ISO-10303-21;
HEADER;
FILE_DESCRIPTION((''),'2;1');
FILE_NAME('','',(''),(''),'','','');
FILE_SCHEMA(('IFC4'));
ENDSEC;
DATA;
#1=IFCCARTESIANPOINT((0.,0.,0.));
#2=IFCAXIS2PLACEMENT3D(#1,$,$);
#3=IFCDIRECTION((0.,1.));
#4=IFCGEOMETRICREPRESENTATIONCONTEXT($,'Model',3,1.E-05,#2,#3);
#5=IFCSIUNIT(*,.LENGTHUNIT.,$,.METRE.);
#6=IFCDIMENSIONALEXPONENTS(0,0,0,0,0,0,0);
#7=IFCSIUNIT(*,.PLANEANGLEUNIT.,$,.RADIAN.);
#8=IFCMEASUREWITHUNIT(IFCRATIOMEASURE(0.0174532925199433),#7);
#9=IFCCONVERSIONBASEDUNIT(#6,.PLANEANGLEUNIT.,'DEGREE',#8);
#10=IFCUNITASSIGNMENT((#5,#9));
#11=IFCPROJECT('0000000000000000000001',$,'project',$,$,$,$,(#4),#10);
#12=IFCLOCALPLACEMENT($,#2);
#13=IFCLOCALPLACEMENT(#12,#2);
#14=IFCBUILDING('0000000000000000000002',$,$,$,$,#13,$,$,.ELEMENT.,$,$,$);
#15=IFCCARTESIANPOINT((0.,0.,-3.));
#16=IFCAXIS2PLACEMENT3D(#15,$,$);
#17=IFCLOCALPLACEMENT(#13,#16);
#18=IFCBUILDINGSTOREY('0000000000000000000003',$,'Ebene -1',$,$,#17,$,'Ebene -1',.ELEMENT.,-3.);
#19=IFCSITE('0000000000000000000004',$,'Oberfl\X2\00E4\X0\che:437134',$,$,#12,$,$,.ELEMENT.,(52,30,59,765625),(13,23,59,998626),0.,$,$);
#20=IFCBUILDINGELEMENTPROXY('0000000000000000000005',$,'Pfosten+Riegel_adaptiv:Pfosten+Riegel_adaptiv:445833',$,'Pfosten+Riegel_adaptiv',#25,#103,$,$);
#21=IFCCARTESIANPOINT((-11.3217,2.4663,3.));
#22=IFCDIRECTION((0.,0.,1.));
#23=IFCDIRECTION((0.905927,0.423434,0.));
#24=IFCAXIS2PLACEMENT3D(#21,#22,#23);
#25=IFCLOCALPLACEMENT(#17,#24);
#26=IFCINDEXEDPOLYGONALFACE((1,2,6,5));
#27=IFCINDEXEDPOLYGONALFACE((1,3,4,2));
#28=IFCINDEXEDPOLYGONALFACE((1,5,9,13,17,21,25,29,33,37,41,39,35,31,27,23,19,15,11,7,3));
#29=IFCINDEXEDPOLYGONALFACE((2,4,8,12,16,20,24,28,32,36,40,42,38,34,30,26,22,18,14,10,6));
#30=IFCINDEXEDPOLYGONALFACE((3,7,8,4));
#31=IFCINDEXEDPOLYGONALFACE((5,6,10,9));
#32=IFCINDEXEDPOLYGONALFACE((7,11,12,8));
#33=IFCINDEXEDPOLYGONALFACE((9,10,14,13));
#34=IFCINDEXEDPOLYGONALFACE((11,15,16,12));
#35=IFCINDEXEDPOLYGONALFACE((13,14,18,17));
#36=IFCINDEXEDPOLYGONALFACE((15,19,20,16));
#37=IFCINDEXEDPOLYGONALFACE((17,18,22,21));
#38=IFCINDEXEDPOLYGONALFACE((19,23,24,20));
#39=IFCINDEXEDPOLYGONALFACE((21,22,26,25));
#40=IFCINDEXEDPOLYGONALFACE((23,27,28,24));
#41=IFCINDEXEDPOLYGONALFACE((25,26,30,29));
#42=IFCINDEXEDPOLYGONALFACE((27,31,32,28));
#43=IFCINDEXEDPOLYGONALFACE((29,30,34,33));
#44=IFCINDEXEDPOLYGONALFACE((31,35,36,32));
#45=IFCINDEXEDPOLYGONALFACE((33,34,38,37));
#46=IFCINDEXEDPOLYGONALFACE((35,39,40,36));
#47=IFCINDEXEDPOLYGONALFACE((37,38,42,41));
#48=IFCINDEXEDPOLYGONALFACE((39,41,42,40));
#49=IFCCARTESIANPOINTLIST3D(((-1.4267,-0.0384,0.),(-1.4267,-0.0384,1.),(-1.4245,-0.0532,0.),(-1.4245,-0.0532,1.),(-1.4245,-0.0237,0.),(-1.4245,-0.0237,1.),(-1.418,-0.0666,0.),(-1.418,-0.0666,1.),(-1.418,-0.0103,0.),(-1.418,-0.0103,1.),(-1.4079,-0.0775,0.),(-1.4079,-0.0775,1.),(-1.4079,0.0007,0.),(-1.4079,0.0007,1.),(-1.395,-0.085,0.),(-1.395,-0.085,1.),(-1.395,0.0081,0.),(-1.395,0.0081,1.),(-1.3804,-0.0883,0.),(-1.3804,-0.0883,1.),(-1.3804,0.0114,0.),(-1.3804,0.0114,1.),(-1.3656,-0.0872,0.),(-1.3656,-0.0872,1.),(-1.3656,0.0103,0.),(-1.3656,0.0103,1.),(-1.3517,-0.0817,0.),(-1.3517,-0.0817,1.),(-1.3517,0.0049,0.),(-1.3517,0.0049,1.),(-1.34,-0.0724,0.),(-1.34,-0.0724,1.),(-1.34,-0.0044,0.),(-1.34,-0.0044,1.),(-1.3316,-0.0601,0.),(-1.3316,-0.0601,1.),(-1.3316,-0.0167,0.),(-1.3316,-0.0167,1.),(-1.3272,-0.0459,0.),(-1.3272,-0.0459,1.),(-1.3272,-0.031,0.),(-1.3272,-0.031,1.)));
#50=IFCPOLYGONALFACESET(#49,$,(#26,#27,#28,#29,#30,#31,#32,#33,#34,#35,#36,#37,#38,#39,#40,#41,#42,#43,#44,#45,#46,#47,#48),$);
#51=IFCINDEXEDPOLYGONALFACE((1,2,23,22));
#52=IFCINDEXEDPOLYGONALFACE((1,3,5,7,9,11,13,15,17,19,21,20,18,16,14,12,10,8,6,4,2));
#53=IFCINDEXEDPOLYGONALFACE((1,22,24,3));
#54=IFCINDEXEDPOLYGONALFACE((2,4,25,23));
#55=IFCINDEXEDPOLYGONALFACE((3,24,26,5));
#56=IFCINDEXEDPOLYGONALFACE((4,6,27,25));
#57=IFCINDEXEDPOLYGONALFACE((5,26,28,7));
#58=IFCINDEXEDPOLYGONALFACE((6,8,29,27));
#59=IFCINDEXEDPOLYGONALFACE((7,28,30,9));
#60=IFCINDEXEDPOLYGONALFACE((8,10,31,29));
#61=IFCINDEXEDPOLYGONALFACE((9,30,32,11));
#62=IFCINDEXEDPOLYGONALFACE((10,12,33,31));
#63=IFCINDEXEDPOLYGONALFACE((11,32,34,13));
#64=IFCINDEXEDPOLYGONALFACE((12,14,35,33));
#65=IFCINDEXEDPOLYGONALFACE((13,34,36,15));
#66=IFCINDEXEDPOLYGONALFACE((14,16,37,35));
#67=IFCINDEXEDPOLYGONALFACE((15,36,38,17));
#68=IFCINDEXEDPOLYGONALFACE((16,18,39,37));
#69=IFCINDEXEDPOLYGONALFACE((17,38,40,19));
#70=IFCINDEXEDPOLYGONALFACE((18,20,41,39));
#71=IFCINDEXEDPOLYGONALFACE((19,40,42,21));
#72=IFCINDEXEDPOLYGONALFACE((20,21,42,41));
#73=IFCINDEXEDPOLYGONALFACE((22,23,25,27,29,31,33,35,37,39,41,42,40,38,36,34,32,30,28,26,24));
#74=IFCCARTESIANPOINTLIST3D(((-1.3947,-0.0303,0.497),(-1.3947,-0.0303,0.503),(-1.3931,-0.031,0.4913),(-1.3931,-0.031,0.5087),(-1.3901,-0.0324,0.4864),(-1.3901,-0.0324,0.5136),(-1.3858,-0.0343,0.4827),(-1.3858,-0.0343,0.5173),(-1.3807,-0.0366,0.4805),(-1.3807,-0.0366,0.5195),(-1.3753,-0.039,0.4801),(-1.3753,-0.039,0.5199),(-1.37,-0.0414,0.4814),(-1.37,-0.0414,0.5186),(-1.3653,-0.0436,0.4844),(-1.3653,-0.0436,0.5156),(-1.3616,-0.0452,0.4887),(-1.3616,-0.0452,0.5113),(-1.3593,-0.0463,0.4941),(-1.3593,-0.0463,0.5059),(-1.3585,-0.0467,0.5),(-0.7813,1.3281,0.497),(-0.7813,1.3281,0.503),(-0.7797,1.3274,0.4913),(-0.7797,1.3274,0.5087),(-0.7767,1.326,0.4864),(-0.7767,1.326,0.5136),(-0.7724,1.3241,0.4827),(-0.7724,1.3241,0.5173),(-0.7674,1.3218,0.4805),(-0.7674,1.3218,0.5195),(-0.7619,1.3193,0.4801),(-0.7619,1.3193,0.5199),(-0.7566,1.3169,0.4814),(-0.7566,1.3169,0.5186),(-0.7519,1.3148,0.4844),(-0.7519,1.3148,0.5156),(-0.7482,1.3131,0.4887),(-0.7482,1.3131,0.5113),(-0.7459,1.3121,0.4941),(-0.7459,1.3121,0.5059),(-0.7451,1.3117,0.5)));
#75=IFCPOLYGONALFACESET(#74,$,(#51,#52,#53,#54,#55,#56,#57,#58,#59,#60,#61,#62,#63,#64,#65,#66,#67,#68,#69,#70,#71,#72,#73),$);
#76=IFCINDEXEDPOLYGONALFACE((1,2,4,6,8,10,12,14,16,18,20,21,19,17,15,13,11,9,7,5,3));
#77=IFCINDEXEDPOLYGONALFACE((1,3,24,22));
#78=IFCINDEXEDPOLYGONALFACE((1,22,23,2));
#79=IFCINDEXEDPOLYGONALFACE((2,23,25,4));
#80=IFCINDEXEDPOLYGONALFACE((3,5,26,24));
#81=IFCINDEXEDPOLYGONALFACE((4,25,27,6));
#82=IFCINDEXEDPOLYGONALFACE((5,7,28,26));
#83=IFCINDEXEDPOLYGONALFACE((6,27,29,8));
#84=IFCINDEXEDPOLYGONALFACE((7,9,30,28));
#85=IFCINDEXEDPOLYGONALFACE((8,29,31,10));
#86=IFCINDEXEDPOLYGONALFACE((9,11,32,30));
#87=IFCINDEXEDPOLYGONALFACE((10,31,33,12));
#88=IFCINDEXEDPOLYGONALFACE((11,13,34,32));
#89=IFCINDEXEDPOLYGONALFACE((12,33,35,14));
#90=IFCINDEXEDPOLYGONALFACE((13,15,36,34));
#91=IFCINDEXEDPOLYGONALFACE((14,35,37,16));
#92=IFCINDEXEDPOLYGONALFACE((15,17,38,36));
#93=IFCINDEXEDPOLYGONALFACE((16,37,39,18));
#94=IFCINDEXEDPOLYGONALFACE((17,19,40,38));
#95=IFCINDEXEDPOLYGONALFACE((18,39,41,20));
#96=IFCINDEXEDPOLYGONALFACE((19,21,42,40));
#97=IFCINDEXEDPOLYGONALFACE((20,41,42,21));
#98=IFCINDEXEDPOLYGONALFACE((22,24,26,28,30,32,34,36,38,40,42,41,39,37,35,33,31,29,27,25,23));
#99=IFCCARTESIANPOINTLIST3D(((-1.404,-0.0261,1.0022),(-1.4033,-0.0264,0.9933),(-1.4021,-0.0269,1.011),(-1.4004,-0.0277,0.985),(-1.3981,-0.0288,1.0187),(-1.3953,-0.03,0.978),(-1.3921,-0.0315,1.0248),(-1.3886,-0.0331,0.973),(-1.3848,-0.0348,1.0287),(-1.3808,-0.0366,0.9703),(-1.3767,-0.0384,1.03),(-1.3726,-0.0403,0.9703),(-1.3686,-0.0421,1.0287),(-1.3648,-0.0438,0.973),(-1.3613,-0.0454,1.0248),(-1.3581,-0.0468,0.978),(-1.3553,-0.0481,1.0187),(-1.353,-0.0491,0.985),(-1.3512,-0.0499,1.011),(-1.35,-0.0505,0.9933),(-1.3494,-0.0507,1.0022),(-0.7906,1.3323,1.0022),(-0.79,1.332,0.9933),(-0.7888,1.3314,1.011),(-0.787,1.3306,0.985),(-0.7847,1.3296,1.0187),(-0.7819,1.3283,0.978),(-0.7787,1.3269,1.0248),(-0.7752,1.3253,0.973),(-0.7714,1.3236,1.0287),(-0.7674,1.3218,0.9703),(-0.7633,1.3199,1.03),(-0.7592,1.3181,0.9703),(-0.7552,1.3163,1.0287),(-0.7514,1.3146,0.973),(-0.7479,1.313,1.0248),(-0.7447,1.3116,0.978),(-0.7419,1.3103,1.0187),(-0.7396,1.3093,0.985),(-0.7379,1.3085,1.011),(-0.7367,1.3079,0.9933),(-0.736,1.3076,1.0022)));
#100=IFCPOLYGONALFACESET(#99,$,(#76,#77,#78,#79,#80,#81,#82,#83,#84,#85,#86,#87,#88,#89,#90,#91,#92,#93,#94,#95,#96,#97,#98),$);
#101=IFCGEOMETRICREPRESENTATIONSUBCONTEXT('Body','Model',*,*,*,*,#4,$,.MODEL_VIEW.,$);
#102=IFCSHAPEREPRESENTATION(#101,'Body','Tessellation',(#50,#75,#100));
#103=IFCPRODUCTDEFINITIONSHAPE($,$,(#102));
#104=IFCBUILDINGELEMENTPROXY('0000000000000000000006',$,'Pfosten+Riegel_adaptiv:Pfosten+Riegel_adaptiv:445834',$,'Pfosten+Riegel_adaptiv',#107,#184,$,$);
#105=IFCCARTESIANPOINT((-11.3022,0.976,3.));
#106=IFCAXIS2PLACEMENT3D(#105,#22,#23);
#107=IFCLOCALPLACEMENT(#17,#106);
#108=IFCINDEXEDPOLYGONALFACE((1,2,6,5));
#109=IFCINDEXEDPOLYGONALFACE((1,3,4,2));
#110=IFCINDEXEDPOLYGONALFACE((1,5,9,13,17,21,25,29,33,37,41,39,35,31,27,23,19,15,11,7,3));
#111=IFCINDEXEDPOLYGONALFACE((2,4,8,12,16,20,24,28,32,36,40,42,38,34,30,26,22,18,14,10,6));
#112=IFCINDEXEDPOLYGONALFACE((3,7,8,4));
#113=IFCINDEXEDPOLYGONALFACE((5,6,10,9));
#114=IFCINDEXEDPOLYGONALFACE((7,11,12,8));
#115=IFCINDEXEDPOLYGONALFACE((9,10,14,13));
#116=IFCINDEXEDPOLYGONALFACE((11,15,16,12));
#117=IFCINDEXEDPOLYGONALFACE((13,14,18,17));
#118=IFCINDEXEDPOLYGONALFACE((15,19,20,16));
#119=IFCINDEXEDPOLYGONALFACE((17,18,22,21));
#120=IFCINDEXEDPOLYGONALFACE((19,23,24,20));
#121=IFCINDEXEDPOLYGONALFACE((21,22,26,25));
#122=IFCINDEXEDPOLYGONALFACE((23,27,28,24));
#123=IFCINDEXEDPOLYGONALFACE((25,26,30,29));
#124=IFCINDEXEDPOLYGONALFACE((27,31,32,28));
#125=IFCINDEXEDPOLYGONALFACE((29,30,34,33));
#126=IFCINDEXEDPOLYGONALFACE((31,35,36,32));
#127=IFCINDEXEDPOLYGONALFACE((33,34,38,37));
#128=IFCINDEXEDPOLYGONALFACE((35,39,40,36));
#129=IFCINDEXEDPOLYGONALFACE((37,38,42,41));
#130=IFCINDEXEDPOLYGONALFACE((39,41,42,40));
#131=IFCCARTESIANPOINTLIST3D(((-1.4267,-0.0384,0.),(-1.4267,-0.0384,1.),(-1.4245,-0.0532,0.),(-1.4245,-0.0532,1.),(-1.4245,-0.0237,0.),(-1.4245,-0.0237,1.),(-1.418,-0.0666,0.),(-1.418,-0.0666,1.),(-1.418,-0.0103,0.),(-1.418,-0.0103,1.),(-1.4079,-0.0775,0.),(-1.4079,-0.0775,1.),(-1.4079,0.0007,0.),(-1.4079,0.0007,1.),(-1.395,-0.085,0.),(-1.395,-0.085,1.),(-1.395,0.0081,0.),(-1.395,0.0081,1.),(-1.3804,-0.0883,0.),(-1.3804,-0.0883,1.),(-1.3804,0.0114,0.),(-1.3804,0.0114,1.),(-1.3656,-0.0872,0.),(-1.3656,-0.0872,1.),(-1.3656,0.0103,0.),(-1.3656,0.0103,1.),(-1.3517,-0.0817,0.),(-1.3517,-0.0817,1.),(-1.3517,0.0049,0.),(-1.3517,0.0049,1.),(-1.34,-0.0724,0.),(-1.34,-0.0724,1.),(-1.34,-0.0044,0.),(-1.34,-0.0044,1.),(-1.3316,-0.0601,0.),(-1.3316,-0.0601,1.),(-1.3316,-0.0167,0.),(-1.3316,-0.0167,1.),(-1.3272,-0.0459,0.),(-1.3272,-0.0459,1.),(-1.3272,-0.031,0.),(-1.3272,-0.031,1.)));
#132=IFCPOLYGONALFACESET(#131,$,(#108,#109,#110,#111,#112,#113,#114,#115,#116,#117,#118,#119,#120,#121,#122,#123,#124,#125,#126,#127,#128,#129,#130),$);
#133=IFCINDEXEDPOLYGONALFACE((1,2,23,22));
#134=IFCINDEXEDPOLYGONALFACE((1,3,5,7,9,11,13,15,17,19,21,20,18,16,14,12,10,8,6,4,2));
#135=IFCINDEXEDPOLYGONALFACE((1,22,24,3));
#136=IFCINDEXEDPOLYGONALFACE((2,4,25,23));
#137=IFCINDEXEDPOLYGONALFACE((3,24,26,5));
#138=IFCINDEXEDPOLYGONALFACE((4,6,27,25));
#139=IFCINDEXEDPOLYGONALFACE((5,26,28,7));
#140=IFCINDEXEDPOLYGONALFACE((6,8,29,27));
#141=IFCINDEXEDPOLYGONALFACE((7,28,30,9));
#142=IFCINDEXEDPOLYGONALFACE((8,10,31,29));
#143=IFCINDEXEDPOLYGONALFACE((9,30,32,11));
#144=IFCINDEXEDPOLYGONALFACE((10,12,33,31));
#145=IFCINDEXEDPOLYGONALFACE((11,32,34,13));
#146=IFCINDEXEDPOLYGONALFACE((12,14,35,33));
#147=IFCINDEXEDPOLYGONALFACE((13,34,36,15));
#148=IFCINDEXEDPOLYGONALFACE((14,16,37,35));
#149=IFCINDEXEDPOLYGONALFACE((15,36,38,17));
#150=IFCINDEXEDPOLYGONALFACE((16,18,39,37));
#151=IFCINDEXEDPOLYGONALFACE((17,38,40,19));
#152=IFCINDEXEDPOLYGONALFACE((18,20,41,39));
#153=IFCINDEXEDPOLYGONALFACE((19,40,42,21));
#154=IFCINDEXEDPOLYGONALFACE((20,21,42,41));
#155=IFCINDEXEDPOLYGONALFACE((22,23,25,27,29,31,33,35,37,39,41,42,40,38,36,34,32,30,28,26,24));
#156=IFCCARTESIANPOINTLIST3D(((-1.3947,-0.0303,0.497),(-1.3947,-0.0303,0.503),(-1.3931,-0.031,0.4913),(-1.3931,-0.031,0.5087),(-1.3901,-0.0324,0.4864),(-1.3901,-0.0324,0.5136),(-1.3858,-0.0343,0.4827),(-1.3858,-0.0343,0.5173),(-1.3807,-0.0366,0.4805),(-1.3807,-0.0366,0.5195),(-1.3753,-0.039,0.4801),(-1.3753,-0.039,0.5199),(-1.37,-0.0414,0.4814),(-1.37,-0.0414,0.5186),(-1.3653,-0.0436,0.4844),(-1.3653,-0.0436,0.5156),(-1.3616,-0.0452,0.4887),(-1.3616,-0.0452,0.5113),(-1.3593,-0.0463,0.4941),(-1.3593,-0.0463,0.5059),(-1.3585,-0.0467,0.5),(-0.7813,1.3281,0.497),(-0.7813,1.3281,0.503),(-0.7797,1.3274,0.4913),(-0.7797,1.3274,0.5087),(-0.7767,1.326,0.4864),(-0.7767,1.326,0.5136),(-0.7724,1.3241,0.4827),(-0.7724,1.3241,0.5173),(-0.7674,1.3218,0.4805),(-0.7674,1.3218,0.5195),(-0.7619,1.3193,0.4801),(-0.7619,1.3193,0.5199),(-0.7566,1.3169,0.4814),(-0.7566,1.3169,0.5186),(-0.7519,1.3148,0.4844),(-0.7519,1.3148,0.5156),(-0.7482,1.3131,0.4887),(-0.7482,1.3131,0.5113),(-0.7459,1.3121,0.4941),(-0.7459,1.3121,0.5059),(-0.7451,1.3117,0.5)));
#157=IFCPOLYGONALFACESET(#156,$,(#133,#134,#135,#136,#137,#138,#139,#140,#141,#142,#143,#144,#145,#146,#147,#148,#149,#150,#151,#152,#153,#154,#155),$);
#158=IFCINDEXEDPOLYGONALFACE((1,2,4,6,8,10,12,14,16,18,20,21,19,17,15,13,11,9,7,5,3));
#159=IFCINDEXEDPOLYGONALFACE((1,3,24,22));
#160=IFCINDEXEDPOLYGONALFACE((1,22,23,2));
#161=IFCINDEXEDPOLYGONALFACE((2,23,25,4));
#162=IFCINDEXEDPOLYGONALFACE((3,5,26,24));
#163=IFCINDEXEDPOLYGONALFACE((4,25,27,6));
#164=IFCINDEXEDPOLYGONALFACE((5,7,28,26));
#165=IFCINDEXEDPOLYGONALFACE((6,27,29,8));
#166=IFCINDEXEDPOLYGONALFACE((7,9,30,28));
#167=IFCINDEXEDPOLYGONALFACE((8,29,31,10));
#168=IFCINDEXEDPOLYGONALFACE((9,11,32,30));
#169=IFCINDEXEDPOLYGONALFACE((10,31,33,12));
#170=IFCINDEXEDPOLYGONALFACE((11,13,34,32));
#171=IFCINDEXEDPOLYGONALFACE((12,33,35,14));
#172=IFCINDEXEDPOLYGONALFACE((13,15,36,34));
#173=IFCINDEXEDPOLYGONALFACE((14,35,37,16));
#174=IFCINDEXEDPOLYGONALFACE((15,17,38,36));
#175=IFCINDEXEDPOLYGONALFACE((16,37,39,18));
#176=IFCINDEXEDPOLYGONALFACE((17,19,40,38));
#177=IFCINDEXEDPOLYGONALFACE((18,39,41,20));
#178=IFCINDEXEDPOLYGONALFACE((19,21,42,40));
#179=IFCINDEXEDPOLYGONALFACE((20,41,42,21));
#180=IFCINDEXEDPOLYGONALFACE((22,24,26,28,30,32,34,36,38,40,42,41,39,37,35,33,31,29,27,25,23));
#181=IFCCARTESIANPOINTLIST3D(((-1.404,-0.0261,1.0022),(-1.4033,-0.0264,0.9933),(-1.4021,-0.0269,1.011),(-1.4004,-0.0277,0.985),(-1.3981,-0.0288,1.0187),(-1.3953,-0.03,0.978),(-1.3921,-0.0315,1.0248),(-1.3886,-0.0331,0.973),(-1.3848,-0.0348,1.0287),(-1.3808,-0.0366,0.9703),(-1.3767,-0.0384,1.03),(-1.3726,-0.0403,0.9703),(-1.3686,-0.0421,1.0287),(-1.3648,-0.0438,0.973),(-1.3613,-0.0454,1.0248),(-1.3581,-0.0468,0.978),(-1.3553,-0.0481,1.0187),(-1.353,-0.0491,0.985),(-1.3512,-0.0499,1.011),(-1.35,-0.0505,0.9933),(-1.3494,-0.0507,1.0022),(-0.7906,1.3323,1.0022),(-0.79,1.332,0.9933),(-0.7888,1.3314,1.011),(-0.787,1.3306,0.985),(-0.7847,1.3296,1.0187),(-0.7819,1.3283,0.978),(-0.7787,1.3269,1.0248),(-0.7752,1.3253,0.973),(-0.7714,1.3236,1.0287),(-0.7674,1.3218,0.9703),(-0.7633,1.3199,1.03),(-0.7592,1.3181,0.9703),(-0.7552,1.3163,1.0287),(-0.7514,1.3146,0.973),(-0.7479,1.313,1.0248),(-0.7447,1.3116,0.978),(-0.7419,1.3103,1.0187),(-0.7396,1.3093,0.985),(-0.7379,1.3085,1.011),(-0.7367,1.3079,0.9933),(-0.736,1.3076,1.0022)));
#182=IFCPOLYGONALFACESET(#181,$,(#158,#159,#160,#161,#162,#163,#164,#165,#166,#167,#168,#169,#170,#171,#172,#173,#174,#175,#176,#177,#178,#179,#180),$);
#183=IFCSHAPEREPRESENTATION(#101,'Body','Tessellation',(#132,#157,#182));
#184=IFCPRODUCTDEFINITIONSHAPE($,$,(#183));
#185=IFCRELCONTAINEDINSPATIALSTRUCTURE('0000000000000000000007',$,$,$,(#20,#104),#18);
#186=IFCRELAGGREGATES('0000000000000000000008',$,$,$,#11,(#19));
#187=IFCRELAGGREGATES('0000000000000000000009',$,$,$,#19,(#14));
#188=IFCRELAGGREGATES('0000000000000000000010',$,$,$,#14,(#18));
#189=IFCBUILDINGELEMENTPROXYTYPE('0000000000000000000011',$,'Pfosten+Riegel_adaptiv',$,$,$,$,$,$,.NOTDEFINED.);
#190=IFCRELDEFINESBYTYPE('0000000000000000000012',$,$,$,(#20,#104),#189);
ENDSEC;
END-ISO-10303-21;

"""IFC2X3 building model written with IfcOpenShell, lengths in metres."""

from ifc_helpers import new_model, entity, si_unit, converted_unit, direction, frame, frame_2d, origin, place, context, subcontext, project, spatial, circle, extrude, source, transform, mapped, type_object, type_shapes, element, save


model = new_model("IFC2X3")

# Units and contexts
model_context = context("Model", 3, precision=1e-05, world=origin(), true_north=direction((0.0, 1.0)))
body_context = subcontext(model_context, "Body", "Model", "MODEL_VIEW")
ifc_project = project(units=[si_unit("LENGTHUNIT", "METRE"), converted_unit("PLANEANGLEUNIT", "DEGREE", entity("IfcRatioMeasure", 0.0174532925199433), si_unit("PLANEANGLEUNIT", "RADIAN"), dimensions=[0, 0, 0, 0, 0, 0, 0])], contexts=[model_context])

# Site, building, storey
site_placement = place(None, origin())
site = spatial("IfcSite", under=ifc_project, at=site_placement, Name="Oberfläche:437134", CompositionType="ELEMENT", RefLatitude=(52, 30, 59, 765625), RefLongitude=(13, 23, 59, 998626), RefElevation=0.0)
building_placement = place(site_placement, origin())
building = spatial("IfcBuilding", under=site, at=building_placement, CompositionType="ELEMENT")
storey_placement = place(building_placement, frame((0.0, 0.0, -3.0)))
storey = spatial("IfcBuildingStorey", under=building, at=storey_placement, Name="Ebene -1", LongName="Ebene -1", CompositionType="ELEMENT", Elevation=-3.0)

# Building element proxies
building_element_proxy_type_1 = type_object("IfcBuildingElementProxyType", Name="Pfosten+Riegel_adaptiv", PredefinedType="NOTDEFINED")
shared_shape_1 = source(origin(), body_context, "Body", "SweptSolid", [
    extrude(circle(Radius=0.05, at=frame_2d((0.0, 0.0), x_axis=(1.0, 0.0))), frame((-1.3767, -0.0384, 0.0), z_axis=(0.0, 0.0, 1.0), x_axis=(-1.0, 0.0, 0.0)), (0.0, 0.0, 1.0), 1.0),
    extrude(circle(Radius=0.02, at=frame_2d((0.0, 0.0), x_axis=(1.0, 0.0))), frame((-1.3767, -0.0384, 0.5), z_axis=(0.411546, 0.911389, 0.0), x_axis=(0.911389, -0.411546, 0.0)), (0.0, 0.0, 1.0), 1.4904),
    extrude(circle(Radius=0.03, at=frame_2d((0.0, 0.0), x_axis=(1.0, 0.0))), frame((-1.3767, -0.0384, 1.0), z_axis=(0.411546, 0.911389, 0.0), x_axis=(0.0, 0.0, 1.0)), (0.0, 0.0, 1.0), 1.4904),
])
type_shapes(building_element_proxy_type_1, [shared_shape_1])
for number, where, z_axis, x_axis, name in (
    (1, (-11.3217, 2.4663, 3.0), (0.0, 0.0, 1.0), (0.905927, 0.423434, 0.0), "Pfosten+Riegel_adaptiv:Pfosten+Riegel_adaptiv:445833"),
    (2, (-11.3022, 0.976, 3.0), (0.0, 0.0, 1.0), (0.905927, 0.423434, 0.0), "Pfosten+Riegel_adaptiv:Pfosten+Riegel_adaptiv:445834"),
):
    element("IfcBuildingElementProxy", number, at=place(storey_placement, frame(where, z_axis=z_axis, x_axis=x_axis)), inside=storey, type_object=building_element_proxy_type_1, Name=name, ObjectType="Pfosten+Riegel_adaptiv", context=body_context, shape_type="MappedRepresentation", body=[
        mapped(shared_shape_1, transform((0.0, 0.0, 0.0), scale=1.0)),
    ])

save(model, "model.ifc")
